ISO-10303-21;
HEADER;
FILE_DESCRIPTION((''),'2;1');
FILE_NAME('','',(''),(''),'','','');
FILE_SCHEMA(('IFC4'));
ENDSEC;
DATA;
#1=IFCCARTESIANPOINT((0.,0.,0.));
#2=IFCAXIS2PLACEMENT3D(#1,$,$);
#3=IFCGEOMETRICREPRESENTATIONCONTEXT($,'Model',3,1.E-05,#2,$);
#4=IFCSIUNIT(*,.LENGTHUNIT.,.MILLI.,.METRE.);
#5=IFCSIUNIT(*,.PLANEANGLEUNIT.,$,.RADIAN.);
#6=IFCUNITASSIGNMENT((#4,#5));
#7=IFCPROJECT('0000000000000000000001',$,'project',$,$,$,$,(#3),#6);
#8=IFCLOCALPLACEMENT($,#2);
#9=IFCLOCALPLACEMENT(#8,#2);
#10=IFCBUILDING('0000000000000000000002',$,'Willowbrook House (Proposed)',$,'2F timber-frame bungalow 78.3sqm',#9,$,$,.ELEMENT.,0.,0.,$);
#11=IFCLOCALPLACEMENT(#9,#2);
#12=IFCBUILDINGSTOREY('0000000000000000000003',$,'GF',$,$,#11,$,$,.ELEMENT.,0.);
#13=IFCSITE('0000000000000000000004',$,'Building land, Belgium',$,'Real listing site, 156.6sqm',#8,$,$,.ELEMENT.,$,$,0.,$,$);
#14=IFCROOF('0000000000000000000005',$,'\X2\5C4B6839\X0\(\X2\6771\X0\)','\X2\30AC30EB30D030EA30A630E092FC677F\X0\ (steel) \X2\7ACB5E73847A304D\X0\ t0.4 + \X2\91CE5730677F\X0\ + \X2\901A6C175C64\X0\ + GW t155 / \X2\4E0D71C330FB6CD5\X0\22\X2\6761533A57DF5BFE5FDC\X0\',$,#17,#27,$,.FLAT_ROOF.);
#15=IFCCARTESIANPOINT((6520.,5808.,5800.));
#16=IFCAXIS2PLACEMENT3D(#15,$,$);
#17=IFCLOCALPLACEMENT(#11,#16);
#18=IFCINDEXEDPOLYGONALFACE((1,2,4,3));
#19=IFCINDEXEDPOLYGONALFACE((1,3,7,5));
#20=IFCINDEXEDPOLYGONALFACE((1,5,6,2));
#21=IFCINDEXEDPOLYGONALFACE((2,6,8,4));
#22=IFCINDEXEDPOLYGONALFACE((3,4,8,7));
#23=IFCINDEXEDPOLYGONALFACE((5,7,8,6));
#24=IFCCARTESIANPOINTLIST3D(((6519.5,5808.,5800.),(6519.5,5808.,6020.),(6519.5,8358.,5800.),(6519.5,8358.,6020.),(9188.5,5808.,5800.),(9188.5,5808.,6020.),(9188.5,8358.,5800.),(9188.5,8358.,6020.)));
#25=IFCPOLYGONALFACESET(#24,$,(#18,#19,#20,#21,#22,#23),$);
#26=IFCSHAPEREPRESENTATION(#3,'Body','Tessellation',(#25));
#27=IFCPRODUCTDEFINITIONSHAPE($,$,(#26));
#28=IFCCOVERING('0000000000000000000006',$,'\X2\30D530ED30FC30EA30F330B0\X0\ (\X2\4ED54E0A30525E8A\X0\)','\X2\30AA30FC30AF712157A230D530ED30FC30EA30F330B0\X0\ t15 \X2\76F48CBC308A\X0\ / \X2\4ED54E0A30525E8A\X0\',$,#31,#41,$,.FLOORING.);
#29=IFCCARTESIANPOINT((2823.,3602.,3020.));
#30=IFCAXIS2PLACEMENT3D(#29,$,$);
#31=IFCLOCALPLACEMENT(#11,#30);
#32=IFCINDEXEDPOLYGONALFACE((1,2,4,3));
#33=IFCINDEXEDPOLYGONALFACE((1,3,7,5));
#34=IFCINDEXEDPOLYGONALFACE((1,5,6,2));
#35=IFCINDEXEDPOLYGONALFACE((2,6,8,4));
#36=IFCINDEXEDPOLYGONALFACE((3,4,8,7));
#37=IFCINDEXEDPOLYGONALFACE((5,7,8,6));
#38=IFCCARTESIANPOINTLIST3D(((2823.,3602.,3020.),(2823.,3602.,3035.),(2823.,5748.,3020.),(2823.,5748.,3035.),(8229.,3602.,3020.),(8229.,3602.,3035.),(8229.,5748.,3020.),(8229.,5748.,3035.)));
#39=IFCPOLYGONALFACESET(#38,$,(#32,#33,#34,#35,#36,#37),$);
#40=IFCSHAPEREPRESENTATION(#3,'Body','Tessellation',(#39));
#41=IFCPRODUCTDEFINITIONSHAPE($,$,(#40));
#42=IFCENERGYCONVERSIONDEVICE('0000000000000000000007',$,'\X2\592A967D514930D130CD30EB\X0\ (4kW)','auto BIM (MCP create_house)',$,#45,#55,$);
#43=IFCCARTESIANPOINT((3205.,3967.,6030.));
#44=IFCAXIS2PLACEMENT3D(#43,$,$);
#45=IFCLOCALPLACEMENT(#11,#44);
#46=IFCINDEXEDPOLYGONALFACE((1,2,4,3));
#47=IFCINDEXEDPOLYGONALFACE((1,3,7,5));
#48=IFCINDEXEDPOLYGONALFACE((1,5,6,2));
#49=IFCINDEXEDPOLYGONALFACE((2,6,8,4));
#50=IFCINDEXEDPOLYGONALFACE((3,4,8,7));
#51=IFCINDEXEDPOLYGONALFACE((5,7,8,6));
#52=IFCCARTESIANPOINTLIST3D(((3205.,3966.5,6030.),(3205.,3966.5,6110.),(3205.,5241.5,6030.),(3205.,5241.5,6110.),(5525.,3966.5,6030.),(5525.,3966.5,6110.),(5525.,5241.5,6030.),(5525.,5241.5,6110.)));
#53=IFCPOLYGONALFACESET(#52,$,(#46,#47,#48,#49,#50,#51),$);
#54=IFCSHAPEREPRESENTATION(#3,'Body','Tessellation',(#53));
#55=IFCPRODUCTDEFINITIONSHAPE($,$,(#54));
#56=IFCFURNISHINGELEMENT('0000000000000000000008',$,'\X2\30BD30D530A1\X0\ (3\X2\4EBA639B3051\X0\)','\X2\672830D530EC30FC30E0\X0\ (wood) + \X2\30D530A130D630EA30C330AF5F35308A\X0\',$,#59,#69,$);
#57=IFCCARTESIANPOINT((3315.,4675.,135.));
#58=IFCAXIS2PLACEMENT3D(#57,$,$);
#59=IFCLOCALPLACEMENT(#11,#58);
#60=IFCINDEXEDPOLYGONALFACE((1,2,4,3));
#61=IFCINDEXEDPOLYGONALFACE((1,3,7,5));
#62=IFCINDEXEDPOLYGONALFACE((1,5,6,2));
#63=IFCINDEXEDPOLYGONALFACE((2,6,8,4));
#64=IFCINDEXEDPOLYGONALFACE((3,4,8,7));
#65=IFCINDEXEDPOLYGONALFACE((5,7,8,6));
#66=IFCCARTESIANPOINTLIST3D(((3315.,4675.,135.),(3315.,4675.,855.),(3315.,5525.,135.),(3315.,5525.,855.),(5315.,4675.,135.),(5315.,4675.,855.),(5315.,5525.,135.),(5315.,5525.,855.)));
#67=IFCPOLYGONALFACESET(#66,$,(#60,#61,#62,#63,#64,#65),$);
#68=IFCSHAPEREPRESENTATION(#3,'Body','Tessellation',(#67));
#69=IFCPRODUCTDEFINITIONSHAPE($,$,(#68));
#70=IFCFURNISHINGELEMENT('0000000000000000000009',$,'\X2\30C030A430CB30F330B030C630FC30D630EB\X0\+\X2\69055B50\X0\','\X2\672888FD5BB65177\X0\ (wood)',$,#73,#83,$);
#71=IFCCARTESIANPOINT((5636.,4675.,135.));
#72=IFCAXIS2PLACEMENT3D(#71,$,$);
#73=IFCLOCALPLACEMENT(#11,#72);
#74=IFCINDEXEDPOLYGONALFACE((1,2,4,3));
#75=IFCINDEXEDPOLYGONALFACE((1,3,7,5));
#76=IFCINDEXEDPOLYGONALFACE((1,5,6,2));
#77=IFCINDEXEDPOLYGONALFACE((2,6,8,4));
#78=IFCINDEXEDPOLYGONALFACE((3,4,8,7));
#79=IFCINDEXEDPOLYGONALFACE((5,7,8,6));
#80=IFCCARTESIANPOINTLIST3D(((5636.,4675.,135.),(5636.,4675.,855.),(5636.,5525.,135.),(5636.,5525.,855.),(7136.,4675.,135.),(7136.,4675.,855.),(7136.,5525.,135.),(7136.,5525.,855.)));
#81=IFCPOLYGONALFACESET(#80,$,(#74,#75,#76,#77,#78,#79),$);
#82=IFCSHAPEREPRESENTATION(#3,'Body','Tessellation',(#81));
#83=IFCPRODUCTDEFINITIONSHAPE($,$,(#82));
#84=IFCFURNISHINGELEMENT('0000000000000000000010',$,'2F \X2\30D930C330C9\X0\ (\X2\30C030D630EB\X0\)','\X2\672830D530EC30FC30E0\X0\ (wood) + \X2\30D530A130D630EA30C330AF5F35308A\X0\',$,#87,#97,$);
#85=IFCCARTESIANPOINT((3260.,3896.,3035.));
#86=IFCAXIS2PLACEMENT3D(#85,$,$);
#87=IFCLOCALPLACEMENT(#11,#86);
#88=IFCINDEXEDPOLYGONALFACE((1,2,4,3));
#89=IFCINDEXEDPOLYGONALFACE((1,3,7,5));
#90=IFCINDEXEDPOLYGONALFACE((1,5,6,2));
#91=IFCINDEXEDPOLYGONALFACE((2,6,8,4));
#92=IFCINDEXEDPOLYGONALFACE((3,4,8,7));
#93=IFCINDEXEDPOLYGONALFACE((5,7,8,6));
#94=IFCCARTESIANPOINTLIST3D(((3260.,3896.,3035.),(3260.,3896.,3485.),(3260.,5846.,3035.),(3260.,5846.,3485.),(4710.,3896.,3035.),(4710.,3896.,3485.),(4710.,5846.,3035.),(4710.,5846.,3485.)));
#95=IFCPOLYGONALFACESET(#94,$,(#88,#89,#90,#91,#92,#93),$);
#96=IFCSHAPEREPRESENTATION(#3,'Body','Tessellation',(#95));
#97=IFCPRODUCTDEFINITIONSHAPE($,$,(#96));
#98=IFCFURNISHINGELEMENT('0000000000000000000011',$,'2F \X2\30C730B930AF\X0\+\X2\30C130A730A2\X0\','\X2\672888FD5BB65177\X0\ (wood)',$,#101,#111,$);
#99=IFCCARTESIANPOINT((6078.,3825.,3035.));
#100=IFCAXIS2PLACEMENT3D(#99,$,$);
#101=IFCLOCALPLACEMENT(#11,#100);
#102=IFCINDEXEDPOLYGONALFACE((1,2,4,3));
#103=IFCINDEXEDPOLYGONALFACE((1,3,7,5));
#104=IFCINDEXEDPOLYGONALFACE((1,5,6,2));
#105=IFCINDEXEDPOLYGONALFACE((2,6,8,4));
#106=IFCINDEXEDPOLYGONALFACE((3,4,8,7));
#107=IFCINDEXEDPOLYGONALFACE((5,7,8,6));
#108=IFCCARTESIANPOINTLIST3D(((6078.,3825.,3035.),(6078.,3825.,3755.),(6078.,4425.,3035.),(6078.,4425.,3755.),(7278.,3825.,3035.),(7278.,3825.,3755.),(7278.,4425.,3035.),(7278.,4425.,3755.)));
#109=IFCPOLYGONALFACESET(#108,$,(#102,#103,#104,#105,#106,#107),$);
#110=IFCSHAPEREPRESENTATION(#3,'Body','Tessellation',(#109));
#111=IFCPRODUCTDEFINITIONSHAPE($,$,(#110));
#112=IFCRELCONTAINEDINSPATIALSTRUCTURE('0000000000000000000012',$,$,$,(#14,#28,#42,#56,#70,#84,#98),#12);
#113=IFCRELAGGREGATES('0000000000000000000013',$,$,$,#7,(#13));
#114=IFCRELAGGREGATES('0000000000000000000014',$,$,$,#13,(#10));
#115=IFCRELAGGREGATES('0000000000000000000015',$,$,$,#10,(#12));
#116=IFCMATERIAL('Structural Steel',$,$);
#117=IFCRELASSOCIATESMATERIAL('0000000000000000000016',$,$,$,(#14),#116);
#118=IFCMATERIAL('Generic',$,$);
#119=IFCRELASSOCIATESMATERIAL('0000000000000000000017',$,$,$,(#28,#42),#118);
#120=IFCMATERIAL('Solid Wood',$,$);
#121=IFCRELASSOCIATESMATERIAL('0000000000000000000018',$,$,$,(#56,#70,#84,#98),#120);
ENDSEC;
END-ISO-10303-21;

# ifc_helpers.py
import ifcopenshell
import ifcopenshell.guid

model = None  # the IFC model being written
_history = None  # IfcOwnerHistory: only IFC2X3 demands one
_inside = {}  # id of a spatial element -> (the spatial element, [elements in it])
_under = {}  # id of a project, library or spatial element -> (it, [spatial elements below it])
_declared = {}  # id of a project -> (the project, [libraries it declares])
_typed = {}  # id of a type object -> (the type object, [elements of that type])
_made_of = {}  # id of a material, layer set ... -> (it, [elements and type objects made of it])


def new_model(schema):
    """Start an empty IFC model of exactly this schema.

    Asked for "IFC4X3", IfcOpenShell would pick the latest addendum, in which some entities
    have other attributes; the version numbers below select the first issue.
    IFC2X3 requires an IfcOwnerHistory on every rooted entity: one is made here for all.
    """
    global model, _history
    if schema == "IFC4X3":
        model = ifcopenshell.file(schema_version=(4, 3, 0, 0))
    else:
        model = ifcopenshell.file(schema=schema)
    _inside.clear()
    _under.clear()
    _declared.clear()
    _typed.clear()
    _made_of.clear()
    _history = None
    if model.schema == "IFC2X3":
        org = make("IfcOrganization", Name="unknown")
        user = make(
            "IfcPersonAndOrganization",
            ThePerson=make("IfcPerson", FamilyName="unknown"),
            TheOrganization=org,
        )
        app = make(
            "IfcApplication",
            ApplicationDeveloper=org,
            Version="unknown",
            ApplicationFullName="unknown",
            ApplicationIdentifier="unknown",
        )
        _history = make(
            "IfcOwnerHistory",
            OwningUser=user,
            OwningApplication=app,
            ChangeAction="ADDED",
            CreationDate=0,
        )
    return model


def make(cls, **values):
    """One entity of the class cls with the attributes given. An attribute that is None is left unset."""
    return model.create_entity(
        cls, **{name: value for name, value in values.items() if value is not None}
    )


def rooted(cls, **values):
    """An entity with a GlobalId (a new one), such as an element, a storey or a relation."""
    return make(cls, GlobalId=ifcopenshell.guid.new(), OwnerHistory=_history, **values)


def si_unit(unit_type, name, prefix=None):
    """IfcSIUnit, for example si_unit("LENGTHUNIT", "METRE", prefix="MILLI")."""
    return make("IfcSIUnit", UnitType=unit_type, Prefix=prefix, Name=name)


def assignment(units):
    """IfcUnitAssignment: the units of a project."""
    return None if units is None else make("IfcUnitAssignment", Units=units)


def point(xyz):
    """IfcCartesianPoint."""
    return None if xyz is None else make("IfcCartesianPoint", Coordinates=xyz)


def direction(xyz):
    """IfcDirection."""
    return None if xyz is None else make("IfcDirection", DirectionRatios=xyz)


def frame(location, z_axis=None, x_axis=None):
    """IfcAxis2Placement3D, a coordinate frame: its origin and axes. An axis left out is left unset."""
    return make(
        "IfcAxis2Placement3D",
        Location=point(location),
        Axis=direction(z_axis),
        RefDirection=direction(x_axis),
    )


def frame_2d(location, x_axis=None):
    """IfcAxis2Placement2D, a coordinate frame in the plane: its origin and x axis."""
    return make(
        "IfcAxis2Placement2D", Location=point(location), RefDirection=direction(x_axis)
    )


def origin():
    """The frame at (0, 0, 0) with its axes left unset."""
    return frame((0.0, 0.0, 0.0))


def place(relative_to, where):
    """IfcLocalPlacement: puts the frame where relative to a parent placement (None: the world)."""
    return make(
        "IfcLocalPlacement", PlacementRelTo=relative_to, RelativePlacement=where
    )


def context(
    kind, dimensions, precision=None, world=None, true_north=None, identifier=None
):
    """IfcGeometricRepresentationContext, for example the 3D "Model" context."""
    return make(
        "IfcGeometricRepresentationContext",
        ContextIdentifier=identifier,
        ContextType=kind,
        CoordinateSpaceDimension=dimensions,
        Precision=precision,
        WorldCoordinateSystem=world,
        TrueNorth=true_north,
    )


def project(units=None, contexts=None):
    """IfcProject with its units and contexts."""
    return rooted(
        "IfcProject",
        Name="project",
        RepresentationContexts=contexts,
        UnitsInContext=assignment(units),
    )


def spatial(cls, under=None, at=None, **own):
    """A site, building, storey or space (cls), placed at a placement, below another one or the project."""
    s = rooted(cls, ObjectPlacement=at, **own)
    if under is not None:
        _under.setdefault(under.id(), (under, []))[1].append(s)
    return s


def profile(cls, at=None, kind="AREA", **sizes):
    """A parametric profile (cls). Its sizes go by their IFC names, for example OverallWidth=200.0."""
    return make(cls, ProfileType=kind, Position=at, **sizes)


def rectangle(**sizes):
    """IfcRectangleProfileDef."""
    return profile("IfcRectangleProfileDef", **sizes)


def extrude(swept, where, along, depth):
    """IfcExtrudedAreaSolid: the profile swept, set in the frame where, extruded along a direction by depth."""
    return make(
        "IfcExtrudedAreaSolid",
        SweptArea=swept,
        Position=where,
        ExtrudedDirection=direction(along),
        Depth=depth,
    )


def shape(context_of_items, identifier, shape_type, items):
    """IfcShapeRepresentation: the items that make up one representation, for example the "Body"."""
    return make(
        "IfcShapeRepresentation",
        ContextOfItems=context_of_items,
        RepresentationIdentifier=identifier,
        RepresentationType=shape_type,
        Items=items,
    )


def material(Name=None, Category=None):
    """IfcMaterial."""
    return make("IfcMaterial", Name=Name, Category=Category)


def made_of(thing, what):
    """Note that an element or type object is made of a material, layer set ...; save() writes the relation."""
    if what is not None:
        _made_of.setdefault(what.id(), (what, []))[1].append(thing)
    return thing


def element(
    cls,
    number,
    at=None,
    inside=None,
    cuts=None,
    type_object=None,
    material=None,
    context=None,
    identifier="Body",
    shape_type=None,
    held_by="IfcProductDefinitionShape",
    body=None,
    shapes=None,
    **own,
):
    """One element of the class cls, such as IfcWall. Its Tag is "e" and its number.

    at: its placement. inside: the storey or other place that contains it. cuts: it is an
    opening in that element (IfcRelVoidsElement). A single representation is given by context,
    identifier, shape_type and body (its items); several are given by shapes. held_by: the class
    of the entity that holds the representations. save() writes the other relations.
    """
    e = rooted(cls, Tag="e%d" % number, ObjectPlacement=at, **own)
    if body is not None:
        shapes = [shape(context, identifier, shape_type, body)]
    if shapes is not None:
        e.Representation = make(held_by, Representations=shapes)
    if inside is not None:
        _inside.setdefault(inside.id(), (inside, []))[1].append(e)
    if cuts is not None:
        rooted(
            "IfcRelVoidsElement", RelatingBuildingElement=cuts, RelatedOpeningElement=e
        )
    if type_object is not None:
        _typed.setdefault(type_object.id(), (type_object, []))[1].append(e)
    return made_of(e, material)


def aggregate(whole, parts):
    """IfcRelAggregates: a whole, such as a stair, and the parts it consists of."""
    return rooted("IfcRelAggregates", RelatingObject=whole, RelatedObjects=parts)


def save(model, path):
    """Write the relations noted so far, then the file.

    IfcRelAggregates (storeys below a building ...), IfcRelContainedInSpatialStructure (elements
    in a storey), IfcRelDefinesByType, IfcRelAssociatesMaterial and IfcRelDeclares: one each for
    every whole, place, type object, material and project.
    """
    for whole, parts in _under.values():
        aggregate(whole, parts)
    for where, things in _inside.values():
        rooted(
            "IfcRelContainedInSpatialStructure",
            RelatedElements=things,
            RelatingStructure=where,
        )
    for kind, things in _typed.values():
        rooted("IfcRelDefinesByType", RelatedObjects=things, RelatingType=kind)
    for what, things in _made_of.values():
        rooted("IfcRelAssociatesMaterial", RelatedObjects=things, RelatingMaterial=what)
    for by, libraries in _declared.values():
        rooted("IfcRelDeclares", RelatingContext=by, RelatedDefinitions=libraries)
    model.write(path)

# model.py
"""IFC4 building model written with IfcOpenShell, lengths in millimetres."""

from ifc_helpers import new_model, si_unit, frame, frame_2d, origin, place, context, project, spatial, rectangle, extrude, material, element, save


model = new_model("IFC4")

# Units and contexts
model_context = context("Model", 3, precision=1e-05, world=origin())
ifc_project = project(units=[si_unit("LENGTHUNIT", "METRE", prefix="MILLI"), si_unit("PLANEANGLEUNIT", "RADIAN")], contexts=[model_context])

# Site, building, storey
site_placement = place(None, origin())
site = spatial("IfcSite", under=ifc_project, at=site_placement, Name="Building land, Belgium", ObjectType="Real listing site, 156.6sqm", CompositionType="ELEMENT", RefElevation=0.0)
building_placement = place(site_placement, origin())
building = spatial("IfcBuilding", under=site, at=building_placement, Name="Willowbrook House (Proposed)", ObjectType="2F timber-frame bungalow 78.3sqm", CompositionType="ELEMENT", ElevationOfRefHeight=0.0, ElevationOfTerrain=0.0)
storey_placement = place(building_placement, origin())
storey = spatial("IfcBuildingStorey", under=building, at=storey_placement, Name="GF", CompositionType="ELEMENT", Elevation=0.0)

# Shared definitions
ifc_material_1 = material(Name="Solid Wood")

# Roof
ifc_material_2 = material(Name="Structural Steel")
roof_1_placement = place(storey_placement, frame((6520.0, 5808.0, 5800.0)))
element("IfcRoof", 1, at=roof_1_placement, inside=storey, material=ifc_material_2, Name="屋根(東)", Description="ガルバリウム鋼板 (steel) 立平葺き t0.4 + 野地板 + 通気層 + GW t155 / 不燃・法22条区域対応", PredefinedType="FLAT_ROOF", context=model_context, shape_type="SweptSolid", body=[
    extrude(rectangle(XDim=2669.0, YDim=2550.0, at=frame_2d((1334.0, 1275.0))), frame((6520.0, 5808.0, 5800.0)), (0.0, 0.0, 1.0), 220.0),
])

# Covering
ifc_material_3 = material(Name="Generic")
covering_placement = place(storey_placement, frame((2823.0, 3602.0, 3020.0)))
element("IfcCovering", 2, at=covering_placement, inside=storey, material=ifc_material_3, Name="フローリング (仕上げ床)", Description="オーク無垢フローリング t15 直貼り / 仕上げ床", PredefinedType="FLOORING", context=model_context, shape_type="SweptSolid", body=[
    extrude(rectangle(XDim=5406.0, YDim=2146.0, at=frame_2d((2703.0, 1073.0))), frame((2823.0, 3602.0, 3020.0)), (0.0, 0.0, 1.0), 15.0),
])

# Energy conversion device
energy_conversion_device_placement = place(storey_placement, frame((3205.0, 3967.0, 6030.0)))
element("IfcEnergyConversionDevice", 3, at=energy_conversion_device_placement, inside=storey, material=ifc_material_3, Name="太陽光パネル (4kW)", Description="auto BIM (MCP create_house)", context=model_context, shape_type="SweptSolid", body=[
    extrude(rectangle(XDim=2320.0, YDim=1275.0, at=frame_2d((1160.0, 637.0))), frame((3205.0, 3967.0, 6030.0)), (0.0, 0.0, 1.0), 80.0),
])

# Furnishing elements
furnishing_1_placement = place(storey_placement, frame((3315.0, 4675.0, 135.0)))
element("IfcFurnishingElement", 4, at=furnishing_1_placement, inside=storey, material=ifc_material_1, Name="ソファ (3人掛け)", Description="木フレーム (wood) + ファブリック張り", context=model_context, shape_type="SweptSolid", body=[
    extrude(rectangle(XDim=2000.0, YDim=850.0, at=frame_2d((1000.0, 425.0))), frame((3315.0, 4675.0, 135.0)), (0.0, 0.0, 1.0), 720.0),
])
furnishing_2_placement = place(storey_placement, frame((5636.0, 4675.0, 135.0)))
element("IfcFurnishingElement", 5, at=furnishing_2_placement, inside=storey, material=ifc_material_1, Name="ダイニングテーブル+椅子", Description="木製家具 (wood)", context=model_context, shape_type="SweptSolid", body=[
    extrude(rectangle(XDim=1500.0, YDim=850.0, at=frame_2d((750.0, 425.0))), frame((5636.0, 4675.0, 135.0)), (0.0, 0.0, 1.0), 720.0),
])
furnishing_3_placement = place(storey_placement, frame((3260.0, 3896.0, 3035.0)))
element("IfcFurnishingElement", 6, at=furnishing_3_placement, inside=storey, material=ifc_material_1, Name="2F ベッド (ダブル)", Description="木フレーム (wood) + ファブリック張り", context=model_context, shape_type="SweptSolid", body=[
    extrude(rectangle(XDim=1450.0, YDim=1950.0, at=frame_2d((725.0, 975.0))), frame((3260.0, 3896.0, 3035.0)), (0.0, 0.0, 1.0), 450.0),
])
furnishing_4_placement = place(storey_placement, frame((6078.0, 3825.0, 3035.0)))
element("IfcFurnishingElement", 7, at=furnishing_4_placement, inside=storey, material=ifc_material_1, Name="2F デスク+チェア", Description="木製家具 (wood)", context=model_context, shape_type="SweptSolid", body=[
    extrude(rectangle(XDim=1200.0, YDim=600.0, at=frame_2d((600.0, 300.0))), frame((6078.0, 3825.0, 3035.0)), (0.0, 0.0, 1.0), 720.0),
])

save(model, "model.ifc")
